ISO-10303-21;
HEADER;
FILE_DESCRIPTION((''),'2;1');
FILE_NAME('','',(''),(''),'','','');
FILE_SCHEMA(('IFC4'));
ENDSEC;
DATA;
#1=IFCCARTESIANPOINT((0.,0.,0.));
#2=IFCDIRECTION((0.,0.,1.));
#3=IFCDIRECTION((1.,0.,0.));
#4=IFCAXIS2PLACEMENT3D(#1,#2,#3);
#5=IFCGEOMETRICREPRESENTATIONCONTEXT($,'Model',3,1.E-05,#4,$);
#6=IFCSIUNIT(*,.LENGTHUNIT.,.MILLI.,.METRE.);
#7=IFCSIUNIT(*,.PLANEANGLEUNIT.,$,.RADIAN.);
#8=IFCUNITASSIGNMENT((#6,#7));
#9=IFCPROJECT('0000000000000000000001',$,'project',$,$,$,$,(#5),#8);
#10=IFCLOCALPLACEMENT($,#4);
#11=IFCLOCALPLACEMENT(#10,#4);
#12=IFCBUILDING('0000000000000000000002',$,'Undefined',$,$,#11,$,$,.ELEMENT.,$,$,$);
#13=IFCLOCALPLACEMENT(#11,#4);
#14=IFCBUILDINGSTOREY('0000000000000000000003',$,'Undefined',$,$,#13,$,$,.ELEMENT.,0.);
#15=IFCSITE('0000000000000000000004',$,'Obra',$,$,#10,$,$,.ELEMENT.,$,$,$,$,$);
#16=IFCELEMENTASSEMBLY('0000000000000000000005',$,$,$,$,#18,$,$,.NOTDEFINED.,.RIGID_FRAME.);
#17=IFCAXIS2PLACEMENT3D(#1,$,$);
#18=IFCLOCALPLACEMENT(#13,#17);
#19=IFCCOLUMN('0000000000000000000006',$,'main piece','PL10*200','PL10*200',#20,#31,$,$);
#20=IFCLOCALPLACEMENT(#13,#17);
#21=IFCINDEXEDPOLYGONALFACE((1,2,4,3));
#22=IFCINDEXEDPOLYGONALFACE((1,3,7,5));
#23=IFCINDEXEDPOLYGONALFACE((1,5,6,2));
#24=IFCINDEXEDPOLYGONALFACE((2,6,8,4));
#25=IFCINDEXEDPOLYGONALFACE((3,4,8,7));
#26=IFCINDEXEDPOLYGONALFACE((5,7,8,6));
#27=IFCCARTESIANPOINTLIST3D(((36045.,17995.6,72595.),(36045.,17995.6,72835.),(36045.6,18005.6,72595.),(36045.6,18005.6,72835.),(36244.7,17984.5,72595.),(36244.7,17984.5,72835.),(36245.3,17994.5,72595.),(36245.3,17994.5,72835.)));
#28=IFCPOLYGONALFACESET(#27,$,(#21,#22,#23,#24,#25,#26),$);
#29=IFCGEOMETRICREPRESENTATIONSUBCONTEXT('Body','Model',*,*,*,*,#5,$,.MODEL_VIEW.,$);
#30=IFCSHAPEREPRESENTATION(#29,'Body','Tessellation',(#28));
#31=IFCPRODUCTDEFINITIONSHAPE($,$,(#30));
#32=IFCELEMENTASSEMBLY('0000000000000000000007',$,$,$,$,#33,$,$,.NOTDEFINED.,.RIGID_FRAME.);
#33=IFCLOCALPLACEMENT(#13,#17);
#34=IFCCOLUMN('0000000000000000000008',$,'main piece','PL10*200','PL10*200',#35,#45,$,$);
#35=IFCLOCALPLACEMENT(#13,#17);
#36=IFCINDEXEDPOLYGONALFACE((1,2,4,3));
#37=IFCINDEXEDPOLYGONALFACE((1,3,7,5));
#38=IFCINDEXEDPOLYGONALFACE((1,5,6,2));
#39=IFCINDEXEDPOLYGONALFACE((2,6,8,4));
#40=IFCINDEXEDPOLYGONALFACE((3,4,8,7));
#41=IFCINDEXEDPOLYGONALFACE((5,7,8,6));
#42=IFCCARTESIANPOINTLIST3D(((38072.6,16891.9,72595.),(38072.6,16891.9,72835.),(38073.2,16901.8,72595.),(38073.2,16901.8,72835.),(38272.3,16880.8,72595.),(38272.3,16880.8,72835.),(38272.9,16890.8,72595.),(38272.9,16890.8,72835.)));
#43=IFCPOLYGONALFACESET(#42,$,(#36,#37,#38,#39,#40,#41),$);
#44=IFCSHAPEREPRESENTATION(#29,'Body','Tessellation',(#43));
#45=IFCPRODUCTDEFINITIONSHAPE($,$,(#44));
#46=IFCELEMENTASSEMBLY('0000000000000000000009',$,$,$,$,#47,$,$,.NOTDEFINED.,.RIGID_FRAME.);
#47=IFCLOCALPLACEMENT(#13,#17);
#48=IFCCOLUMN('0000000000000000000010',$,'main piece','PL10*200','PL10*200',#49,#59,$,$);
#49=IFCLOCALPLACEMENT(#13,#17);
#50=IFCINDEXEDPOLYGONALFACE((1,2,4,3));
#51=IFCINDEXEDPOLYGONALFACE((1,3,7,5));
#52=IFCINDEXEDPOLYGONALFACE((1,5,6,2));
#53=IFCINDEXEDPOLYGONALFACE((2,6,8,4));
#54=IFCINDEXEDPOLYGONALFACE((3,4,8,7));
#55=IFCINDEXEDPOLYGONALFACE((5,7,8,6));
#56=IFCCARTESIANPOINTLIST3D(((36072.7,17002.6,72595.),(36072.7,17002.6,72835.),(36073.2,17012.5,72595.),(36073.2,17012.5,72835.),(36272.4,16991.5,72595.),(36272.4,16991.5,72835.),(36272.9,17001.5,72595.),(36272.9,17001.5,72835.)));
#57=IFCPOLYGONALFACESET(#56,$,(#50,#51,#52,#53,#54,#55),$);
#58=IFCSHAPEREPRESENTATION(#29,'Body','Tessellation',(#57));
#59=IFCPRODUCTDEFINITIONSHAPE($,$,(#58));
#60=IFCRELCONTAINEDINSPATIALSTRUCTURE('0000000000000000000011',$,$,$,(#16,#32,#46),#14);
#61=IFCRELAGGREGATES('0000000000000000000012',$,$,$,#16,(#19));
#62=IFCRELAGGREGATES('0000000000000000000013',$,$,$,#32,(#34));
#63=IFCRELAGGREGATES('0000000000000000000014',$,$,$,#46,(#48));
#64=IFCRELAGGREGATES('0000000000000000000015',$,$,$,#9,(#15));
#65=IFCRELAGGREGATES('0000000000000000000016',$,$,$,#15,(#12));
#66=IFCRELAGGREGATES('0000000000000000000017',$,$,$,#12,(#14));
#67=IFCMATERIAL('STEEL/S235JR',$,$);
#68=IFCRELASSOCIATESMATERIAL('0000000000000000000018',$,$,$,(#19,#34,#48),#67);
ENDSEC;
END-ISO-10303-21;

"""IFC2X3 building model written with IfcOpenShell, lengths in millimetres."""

from ifc_helpers import new_model, si_unit, frame, origin_with_axes, origin_2d_with_axis, place, context, subcontext, project, spatial, rectangle, extrude, material, element, aggregate, save


model = new_model("IFC2X3")

# Units and contexts
model_context = context("Model", 3, precision=1e-05, world=origin_with_axes())
body_context = subcontext(model_context, "Body", "Model", "MODEL_VIEW")
ifc_project = project(units=[si_unit("LENGTHUNIT", "METRE", prefix="MILLI"), si_unit("PLANEANGLEUNIT", "RADIAN")], contexts=[model_context])

# Site, building, storey
site_placement = place(None, origin_with_axes())
site = spatial("IfcSite", under=ifc_project, at=site_placement, Name="Obra", CompositionType="ELEMENT")
building_placement = place(site_placement, origin_with_axes())
building = spatial("IfcBuilding", under=site, at=building_placement, Name="Undefined", CompositionType="ELEMENT")
storey_placement = place(building_placement, origin_with_axes())
storey = spatial("IfcBuildingStorey", under=building, at=storey_placement, Name="Undefined", CompositionType="ELEMENT", Elevation=0.0)

# Element assemblies, columns
assembly_1_placement = place(storey_placement, origin_with_axes())
assembly_1 = element("IfcElementAssembly", 1, at=assembly_1_placement, inside=storey, AssemblyPlace="NOTDEFINED", PredefinedType="RIGID_FRAME")
ifc_material = material(Name="STEEL/S235JR")
column_1_placement = place(assembly_1_placement, frame((36145.2, 17995.1, 72595.0), z_axis=(0.0, 0.0, 1.0), x_axis=(0.998472, -0.055268, 0.0)))
column_1 = element("IfcColumn", 2, at=column_1_placement, material=ifc_material, Name="main piece", Description="PL10*200", ObjectType="PL10*200", context=body_context, shape_type="SweptSolid", body=[
    extrude(rectangle(XDim=10.0, YDim=200.0, at=origin_2d_with_axis()), frame((0.0, 0.0, 240.0), z_axis=(0.0, 0.0, -1.0), x_axis=(0.0, 1.0, 0.0)), (0.0, 0.0, 1.0), 240.0),
])
assembly_2_placement = place(storey_placement, origin_with_axes())
assembly_2 = element("IfcElementAssembly", 3, at=assembly_2_placement, inside=storey, AssemblyPlace="NOTDEFINED", PredefinedType="RIGID_FRAME")
column_2_placement = place(assembly_2_placement, frame((38172.7, 16891.3, 72595.0), z_axis=(0.0, 0.0, 1.0), x_axis=(-0.998472, 0.055268, 0.0)))
column_2 = element("IfcColumn", 4, at=column_2_placement, material=ifc_material, Name="main piece", Description="PL10*200", ObjectType="PL10*200", context=body_context, shape_type="SweptSolid", body=[
    extrude(rectangle(XDim=10.0, YDim=200.0, at=origin_2d_with_axis()), frame((0.0, 0.0, 240.0), z_axis=(0.0, 0.0, -1.0), x_axis=(0.0, 1.0, 0.0)), (0.0, 0.0, 1.0), 240.0),
])
assembly_3_placement = place(storey_placement, origin_with_axes())
assembly_3 = element("IfcElementAssembly", 5, at=assembly_3_placement, inside=storey, AssemblyPlace="NOTDEFINED", PredefinedType="RIGID_FRAME")
column_3_placement = place(assembly_3_placement, frame((36172.8, 17002.0, 72595.0), z_axis=(0.0, 0.0, 1.0), x_axis=(-0.998472, 0.055268, 0.0)))
column_3 = element("IfcColumn", 6, at=column_3_placement, material=ifc_material, Name="main piece", Description="PL10*200", ObjectType="PL10*200", context=body_context, shape_type="SweptSolid", body=[
    extrude(rectangle(XDim=10.0, YDim=200.0, at=origin_2d_with_axis()), frame((0.0, 0.0, 240.0), z_axis=(0.0, 0.0, -1.0), x_axis=(0.0, 1.0, 0.0)), (0.0, 0.0, 1.0), 240.0),
])

aggregate(assembly_1, [column_1])
aggregate(assembly_2, [column_2])
aggregate(assembly_3, [column_3])

save(model, "model.ifc")
